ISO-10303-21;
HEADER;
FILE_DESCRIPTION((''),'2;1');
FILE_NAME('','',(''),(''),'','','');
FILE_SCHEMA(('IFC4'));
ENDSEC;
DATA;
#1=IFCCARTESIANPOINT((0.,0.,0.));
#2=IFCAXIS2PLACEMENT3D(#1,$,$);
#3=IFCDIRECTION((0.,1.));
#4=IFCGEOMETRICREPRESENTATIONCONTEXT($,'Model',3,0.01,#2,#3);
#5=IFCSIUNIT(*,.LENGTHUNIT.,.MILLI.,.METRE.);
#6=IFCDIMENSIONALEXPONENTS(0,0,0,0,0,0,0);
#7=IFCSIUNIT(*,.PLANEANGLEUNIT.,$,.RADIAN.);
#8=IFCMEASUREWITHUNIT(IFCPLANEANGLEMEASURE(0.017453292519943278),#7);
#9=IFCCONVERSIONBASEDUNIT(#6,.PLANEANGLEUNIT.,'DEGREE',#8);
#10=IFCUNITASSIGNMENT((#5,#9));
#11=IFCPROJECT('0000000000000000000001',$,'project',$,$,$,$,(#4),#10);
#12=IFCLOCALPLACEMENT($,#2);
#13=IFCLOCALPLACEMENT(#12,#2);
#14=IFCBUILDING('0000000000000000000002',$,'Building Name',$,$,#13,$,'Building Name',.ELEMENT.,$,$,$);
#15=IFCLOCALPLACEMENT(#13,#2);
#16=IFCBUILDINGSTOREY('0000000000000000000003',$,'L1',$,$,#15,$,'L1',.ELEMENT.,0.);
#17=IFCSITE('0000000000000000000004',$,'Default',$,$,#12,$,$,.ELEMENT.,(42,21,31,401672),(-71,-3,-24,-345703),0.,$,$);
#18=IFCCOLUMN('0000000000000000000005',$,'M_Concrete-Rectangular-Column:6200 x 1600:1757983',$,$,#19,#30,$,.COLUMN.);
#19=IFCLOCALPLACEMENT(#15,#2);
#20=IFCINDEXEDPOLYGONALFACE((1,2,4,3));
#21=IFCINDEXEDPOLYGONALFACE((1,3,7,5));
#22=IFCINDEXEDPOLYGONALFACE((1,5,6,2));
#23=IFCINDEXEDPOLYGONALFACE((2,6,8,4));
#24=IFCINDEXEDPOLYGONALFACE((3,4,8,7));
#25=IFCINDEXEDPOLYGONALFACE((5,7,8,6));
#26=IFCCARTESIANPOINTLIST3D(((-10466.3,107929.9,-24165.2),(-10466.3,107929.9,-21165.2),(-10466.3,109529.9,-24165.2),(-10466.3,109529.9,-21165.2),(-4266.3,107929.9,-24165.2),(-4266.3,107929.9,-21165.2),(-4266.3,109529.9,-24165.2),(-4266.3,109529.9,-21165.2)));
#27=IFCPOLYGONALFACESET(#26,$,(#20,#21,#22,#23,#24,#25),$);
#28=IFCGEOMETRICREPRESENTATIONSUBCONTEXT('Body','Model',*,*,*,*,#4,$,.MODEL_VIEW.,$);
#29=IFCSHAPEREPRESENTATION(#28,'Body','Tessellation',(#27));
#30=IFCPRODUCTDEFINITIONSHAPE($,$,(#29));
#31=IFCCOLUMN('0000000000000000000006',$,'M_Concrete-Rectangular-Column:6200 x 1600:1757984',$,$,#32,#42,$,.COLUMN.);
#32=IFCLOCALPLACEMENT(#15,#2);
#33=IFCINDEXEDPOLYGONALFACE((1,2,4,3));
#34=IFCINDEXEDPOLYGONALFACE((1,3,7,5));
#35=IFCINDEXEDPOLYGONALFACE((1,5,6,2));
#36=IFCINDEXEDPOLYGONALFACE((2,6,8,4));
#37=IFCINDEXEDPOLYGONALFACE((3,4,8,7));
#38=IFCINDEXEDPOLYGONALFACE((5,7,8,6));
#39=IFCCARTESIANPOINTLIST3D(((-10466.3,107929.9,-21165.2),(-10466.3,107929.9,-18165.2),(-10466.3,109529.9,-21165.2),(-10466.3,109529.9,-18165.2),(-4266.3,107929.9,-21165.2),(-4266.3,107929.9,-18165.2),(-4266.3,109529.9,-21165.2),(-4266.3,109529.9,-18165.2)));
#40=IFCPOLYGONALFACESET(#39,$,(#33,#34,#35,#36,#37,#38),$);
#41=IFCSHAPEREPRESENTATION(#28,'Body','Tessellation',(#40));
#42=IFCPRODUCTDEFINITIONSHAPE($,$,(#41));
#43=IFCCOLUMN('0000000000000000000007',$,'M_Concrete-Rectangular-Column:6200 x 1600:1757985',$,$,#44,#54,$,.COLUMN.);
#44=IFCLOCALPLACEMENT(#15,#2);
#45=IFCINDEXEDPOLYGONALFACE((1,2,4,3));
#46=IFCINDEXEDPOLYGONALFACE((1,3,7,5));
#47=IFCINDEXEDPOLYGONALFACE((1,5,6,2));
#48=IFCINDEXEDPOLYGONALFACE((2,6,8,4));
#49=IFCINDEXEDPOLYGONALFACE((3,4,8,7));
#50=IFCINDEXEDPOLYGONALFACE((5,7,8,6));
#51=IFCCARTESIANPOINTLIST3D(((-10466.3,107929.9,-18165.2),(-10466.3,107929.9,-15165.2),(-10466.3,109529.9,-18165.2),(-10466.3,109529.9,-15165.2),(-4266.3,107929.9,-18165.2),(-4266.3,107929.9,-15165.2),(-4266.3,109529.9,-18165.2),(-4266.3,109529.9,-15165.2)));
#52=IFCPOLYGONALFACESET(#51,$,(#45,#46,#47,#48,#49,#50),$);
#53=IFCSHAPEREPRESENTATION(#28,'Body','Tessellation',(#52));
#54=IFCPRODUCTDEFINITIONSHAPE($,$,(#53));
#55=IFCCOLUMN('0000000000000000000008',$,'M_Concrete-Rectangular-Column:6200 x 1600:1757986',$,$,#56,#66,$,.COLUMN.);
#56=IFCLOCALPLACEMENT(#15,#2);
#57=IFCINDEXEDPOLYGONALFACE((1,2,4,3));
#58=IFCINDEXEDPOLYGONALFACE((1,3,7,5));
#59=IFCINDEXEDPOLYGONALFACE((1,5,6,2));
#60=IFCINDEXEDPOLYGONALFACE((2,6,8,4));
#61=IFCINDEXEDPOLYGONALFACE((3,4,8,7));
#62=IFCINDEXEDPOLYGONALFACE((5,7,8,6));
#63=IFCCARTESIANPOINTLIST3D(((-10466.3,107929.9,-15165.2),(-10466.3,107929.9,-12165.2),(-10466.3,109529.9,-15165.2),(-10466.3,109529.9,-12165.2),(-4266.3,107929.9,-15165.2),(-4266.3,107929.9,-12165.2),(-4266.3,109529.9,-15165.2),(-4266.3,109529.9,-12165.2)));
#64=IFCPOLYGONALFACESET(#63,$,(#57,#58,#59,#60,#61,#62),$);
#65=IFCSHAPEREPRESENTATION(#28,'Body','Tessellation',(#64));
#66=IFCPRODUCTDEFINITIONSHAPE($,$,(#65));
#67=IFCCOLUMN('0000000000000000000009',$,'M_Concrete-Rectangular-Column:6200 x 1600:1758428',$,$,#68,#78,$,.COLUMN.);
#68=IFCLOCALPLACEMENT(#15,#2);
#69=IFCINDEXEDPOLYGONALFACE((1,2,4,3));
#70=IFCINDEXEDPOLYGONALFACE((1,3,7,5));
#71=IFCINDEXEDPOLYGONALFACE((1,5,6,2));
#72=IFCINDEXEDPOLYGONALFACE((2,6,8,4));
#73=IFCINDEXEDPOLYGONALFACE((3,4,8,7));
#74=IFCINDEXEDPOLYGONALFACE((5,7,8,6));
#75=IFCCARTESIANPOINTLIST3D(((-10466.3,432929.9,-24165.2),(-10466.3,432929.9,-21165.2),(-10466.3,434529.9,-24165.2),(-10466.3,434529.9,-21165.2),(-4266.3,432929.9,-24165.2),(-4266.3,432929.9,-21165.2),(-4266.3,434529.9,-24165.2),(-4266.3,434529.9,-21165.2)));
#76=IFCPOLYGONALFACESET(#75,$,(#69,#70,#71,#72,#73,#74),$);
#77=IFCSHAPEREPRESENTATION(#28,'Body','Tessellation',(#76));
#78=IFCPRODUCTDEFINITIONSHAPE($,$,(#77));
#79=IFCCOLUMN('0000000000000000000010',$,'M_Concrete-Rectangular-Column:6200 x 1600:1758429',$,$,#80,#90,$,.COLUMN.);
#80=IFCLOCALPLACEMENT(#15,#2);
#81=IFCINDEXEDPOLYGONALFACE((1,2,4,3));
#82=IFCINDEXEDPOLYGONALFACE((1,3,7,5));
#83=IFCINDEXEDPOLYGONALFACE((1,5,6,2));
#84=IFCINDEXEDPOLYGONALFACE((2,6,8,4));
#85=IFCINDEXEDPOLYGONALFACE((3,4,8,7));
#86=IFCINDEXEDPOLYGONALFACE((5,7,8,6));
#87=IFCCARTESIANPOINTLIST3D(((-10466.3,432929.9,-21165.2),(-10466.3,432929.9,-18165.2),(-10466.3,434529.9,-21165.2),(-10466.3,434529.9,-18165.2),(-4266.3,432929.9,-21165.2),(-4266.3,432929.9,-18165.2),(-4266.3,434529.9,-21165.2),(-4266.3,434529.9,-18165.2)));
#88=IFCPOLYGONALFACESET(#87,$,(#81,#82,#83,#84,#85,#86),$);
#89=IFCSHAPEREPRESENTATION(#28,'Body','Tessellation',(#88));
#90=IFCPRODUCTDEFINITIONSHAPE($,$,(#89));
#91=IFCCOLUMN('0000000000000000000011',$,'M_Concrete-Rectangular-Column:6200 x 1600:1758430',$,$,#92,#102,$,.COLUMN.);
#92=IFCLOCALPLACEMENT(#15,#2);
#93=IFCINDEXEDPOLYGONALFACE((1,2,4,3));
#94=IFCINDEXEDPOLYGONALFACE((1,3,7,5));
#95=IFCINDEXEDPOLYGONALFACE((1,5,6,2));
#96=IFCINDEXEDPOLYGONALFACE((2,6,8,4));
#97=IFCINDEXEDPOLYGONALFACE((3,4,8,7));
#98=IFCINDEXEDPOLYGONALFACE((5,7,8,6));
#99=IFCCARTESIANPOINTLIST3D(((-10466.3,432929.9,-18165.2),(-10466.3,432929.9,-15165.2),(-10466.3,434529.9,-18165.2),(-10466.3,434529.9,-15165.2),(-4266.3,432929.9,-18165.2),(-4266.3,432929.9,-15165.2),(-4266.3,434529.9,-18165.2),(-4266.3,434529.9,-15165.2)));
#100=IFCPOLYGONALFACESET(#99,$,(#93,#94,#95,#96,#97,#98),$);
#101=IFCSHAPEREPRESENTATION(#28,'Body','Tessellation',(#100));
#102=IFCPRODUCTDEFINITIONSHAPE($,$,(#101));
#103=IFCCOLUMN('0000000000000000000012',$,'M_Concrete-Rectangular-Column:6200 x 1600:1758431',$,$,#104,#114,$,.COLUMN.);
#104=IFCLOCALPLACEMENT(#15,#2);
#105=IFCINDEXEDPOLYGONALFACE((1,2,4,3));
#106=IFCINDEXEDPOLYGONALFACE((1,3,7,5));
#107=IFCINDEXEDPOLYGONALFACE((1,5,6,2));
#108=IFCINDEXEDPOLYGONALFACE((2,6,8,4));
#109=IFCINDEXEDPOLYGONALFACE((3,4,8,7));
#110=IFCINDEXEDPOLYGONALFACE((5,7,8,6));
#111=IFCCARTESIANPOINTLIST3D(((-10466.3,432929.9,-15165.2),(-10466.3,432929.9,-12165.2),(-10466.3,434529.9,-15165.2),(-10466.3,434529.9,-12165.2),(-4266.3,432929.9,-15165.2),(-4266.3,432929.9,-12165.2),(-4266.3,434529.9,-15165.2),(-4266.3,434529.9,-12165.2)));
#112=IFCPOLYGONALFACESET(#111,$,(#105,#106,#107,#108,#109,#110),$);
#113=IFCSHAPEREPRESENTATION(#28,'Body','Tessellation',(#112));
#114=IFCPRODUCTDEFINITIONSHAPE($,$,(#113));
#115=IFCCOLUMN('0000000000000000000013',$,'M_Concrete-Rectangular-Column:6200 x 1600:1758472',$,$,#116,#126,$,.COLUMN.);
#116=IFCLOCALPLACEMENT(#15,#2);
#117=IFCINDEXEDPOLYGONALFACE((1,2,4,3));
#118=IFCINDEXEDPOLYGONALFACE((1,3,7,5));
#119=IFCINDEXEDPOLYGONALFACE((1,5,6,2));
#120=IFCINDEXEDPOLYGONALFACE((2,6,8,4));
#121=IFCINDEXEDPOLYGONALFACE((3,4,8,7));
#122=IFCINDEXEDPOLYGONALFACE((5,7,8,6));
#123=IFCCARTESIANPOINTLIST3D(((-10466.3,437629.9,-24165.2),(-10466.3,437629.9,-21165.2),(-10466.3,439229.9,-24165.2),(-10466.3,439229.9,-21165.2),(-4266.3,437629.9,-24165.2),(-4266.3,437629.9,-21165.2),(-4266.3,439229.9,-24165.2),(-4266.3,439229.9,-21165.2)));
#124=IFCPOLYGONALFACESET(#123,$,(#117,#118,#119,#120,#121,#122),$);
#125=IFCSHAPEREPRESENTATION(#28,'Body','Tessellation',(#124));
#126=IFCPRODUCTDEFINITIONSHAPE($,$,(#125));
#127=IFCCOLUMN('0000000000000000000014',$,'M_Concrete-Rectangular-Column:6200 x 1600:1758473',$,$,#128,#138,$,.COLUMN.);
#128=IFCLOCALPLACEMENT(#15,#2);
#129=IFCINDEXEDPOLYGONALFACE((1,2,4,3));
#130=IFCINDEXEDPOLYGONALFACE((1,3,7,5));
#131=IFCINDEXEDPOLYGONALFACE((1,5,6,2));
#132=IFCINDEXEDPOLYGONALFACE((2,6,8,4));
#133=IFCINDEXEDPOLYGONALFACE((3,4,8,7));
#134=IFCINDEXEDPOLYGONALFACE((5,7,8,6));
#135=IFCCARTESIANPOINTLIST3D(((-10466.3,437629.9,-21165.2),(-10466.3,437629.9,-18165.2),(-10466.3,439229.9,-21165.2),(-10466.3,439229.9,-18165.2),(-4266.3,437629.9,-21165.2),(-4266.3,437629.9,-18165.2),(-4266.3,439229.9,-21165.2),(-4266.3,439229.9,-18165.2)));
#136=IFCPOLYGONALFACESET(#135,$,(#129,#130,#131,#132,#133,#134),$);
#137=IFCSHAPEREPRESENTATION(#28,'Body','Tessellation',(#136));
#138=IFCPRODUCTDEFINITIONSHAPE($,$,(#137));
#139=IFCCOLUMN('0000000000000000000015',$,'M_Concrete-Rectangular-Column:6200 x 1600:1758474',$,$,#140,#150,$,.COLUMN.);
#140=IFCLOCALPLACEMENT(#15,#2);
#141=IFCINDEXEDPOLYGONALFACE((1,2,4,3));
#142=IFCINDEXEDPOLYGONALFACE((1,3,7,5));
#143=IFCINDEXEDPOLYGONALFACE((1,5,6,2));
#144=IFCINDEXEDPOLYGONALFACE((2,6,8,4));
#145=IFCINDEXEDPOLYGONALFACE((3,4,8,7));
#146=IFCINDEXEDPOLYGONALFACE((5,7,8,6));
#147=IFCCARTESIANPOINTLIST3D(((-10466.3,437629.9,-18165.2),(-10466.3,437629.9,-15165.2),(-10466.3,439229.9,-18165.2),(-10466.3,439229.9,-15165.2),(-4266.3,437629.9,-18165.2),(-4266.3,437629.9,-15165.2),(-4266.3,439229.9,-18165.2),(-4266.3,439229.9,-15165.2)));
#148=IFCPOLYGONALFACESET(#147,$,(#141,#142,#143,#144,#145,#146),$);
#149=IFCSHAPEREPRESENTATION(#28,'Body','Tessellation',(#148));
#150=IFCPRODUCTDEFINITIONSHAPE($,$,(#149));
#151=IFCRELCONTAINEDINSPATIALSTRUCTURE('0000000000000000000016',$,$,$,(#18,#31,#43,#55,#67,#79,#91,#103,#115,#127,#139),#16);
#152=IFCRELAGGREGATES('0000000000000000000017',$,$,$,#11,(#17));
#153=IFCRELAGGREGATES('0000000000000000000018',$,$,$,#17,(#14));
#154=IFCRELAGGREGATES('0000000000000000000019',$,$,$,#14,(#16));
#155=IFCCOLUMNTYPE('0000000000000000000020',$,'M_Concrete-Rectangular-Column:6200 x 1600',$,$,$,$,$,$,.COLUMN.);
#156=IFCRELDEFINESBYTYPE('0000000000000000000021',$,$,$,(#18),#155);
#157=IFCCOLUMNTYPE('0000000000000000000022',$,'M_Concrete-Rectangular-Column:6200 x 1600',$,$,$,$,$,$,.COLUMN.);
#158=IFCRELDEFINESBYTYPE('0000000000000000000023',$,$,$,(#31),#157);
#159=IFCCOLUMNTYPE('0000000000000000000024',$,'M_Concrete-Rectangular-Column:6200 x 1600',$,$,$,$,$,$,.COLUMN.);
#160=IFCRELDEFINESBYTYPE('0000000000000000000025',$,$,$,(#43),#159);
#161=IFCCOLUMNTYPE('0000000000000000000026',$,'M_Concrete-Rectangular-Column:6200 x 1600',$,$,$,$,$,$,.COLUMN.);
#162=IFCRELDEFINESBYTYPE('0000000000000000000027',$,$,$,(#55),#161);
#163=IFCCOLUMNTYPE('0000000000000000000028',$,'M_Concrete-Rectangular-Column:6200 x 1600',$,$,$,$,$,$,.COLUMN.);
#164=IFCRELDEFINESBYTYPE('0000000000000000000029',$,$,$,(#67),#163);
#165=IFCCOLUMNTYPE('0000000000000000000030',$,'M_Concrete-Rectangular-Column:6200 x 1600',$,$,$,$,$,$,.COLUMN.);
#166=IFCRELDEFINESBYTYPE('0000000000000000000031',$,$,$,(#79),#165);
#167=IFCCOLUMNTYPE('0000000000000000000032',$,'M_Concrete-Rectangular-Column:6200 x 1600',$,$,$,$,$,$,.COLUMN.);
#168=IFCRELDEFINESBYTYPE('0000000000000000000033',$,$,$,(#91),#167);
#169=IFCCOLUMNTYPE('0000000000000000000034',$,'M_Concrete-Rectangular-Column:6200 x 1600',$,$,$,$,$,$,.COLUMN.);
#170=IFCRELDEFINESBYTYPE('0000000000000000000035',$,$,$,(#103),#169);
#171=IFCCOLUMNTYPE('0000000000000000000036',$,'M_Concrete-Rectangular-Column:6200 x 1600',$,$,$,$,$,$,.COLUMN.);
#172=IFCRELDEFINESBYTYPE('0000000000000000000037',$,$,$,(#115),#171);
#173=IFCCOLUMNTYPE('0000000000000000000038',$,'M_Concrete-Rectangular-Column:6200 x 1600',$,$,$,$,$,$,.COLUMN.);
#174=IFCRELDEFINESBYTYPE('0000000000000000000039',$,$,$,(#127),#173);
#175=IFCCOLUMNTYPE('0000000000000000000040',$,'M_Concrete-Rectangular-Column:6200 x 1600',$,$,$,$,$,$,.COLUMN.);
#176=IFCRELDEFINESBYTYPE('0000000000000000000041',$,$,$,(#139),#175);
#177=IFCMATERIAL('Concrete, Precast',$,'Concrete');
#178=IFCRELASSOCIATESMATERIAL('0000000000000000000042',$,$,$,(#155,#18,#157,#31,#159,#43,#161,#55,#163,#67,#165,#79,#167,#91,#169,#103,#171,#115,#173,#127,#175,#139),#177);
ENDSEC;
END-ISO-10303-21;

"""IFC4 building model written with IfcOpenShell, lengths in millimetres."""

from ifc_helpers import new_model, entity, si_unit, converted_unit, direction, frame, origin, place, context, subcontext, project, spatial, indexed_curve, outline, extrude, source, transform, mapped, material, type_object, type_shapes, element, save


model = new_model("IFC4")

# Units and contexts
model_context = context("Model", 3, precision=0.01, world=origin(), true_north=direction((0.0, 1.0)))
body_context = subcontext(model_context, "Body", "Model", "MODEL_VIEW")
ifc_project = project(units=[si_unit("LENGTHUNIT", "METRE", prefix="MILLI"), converted_unit("PLANEANGLEUNIT", "DEGREE", entity("IfcPlaneAngleMeasure", 0.017453292519943278), si_unit("PLANEANGLEUNIT", "RADIAN"), dimensions=[0, 0, 0, 0, 0, 0, 0])], contexts=[model_context])

# Site, building, storey
site_placement = place(None, origin())
site = spatial("IfcSite", under=ifc_project, at=site_placement, Name="Default", CompositionType="ELEMENT", RefLatitude=(42, 21, 31, 401672), RefLongitude=(-71, -3, -24, -345703), RefElevation=0.0)
building_placement = place(site_placement, origin())
building = spatial("IfcBuilding", under=site, at=building_placement, Name="Building Name", LongName="Building Name", CompositionType="ELEMENT")
storey_placement = place(building_placement, origin())
storey = spatial("IfcBuildingStorey", under=building, at=storey_placement, Name="L1", LongName="L1", CompositionType="ELEMENT", Elevation=0.0)

# Columns
ifc_material_1 = material(Name="Concrete, Precast", Category="Concrete")
column_type_1 = type_object("IfcColumnType", Name="M_Concrete-Rectangular-Column:6200 x 1600", PredefinedType="COLUMN", material=ifc_material_1)
shared_shape_1 = source(origin(), body_context, "Body", "SweptSolid", [
    extrude(outline(indexed_curve([(-800.0, -3100.0), (800.0, -3100.0), (800.0, 3100.0), (-800.0, 3100.0), (-800.0, -3100.0)], self_intersect=False)), frame((-7366.3, 108729.9, -24165.2), z_axis=(0.0, 0.0, 1.0), x_axis=(0.0, -1.0, 0.0)), (0.0, 0.0, 1.0), 3000.0),
])
type_shapes(column_type_1, [shared_shape_1])
column_1_placement = place(storey_placement, origin())
element("IfcColumn", 1, at=column_1_placement, inside=storey, type_object=column_type_1, material=ifc_material_1, Name="M_Concrete-Rectangular-Column:6200 x 1600:1757983", PredefinedType="COLUMN", context=body_context, shape_type="MappedRepresentation", body=[
    mapped(shared_shape_1, transform((0.0, 0.0, 0.0), scale=1.0)),
])
column_type_2 = type_object("IfcColumnType", Name="M_Concrete-Rectangular-Column:6200 x 1600", PredefinedType="COLUMN", material=ifc_material_1)
shared_shape_2 = source(origin(), body_context, "Body", "SweptSolid", [
    extrude(outline(indexed_curve([(-800.0, -3100.0), (800.0, -3100.0), (800.0, 3100.0), (-800.0, 3100.0), (-800.0, -3100.0)], self_intersect=False)), frame((-7366.3, 108729.9, -21165.2), z_axis=(0.0, 0.0, 1.0), x_axis=(0.0, -1.0, 0.0)), (0.0, 0.0, 1.0), 3000.0),
])
type_shapes(column_type_2, [shared_shape_2])
column_2_placement = place(storey_placement, origin())
element("IfcColumn", 2, at=column_2_placement, inside=storey, type_object=column_type_2, material=ifc_material_1, Name="M_Concrete-Rectangular-Column:6200 x 1600:1757984", PredefinedType="COLUMN", context=body_context, shape_type="MappedRepresentation", body=[
    mapped(shared_shape_2, transform((0.0, 0.0, 0.0), scale=1.0)),
])
column_type_3 = type_object("IfcColumnType", Name="M_Concrete-Rectangular-Column:6200 x 1600", PredefinedType="COLUMN", material=ifc_material_1)
shared_shape_3 = source(origin(), body_context, "Body", "SweptSolid", [
    extrude(outline(indexed_curve([(-800.0, -3100.0), (800.0, -3100.0), (800.0, 3100.0), (-800.0, 3100.0), (-800.0, -3100.0)], self_intersect=False)), frame((-7366.3, 108729.9, -18165.2), z_axis=(0.0, 0.0, 1.0), x_axis=(0.0, -1.0, 0.0)), (0.0, 0.0, 1.0), 3000.0),
])
type_shapes(column_type_3, [shared_shape_3])
column_3_placement = place(storey_placement, origin())
element("IfcColumn", 3, at=column_3_placement, inside=storey, type_object=column_type_3, material=ifc_material_1, Name="M_Concrete-Rectangular-Column:6200 x 1600:1757985", PredefinedType="COLUMN", context=body_context, shape_type="MappedRepresentation", body=[
    mapped(shared_shape_3, transform((0.0, 0.0, 0.0), scale=1.0)),
])
column_type_4 = type_object("IfcColumnType", Name="M_Concrete-Rectangular-Column:6200 x 1600", PredefinedType="COLUMN", material=ifc_material_1)
shared_shape_4 = source(origin(), body_context, "Body", "SweptSolid", [
    extrude(outline(indexed_curve([(-800.0, -3100.0), (800.0, -3100.0), (800.0, 3100.0), (-800.0, 3100.0), (-800.0, -3100.0)], self_intersect=False)), frame((-7366.3, 108729.9, -15165.2), z_axis=(0.0, 0.0, 1.0), x_axis=(0.0, -1.0, 0.0)), (0.0, 0.0, 1.0), 3000.0),
])
type_shapes(column_type_4, [shared_shape_4])
column_4_placement = place(storey_placement, origin())
element("IfcColumn", 4, at=column_4_placement, inside=storey, type_object=column_type_4, material=ifc_material_1, Name="M_Concrete-Rectangular-Column:6200 x 1600:1757986", PredefinedType="COLUMN", context=body_context, shape_type="MappedRepresentation", body=[
    mapped(shared_shape_4, transform((0.0, 0.0, 0.0), scale=1.0)),
])
column_type_5 = type_object("IfcColumnType", Name="M_Concrete-Rectangular-Column:6200 x 1600", PredefinedType="COLUMN", material=ifc_material_1)
shared_shape_5 = source(origin(), body_context, "Body", "SweptSolid", [
    extrude(outline(indexed_curve([(-800.0, -3100.0), (800.0, -3100.0), (800.0, 3100.0), (-800.0, 3100.0), (-800.0, -3100.0)], self_intersect=False)), frame((-7366.3, 433729.9, -24165.2), z_axis=(0.0, 0.0, 1.0), x_axis=(0.0, -1.0, 0.0)), (0.0, 0.0, 1.0), 3000.0),
])
type_shapes(column_type_5, [shared_shape_5])
column_5_placement = place(storey_placement, origin())
element("IfcColumn", 5, at=column_5_placement, inside=storey, type_object=column_type_5, material=ifc_material_1, Name="M_Concrete-Rectangular-Column:6200 x 1600:1758428", PredefinedType="COLUMN", context=body_context, shape_type="MappedRepresentation", body=[
    mapped(shared_shape_5, transform((0.0, 0.0, 0.0), scale=1.0)),
])
column_type_6 = type_object("IfcColumnType", Name="M_Concrete-Rectangular-Column:6200 x 1600", PredefinedType="COLUMN", material=ifc_material_1)
shared_shape_6 = source(origin(), body_context, "Body", "SweptSolid", [
    extrude(outline(indexed_curve([(-800.0, -3100.0), (800.0, -3100.0), (800.0, 3100.0), (-800.0, 3100.0), (-800.0, -3100.0)], self_intersect=False)), frame((-7366.3, 433729.9, -21165.2), z_axis=(0.0, 0.0, 1.0), x_axis=(0.0, -1.0, 0.0)), (0.0, 0.0, 1.0), 3000.0),
])
type_shapes(column_type_6, [shared_shape_6])
column_6_placement = place(storey_placement, origin())
element("IfcColumn", 6, at=column_6_placement, inside=storey, type_object=column_type_6, material=ifc_material_1, Name="M_Concrete-Rectangular-Column:6200 x 1600:1758429", PredefinedType="COLUMN", context=body_context, shape_type="MappedRepresentation", body=[
    mapped(shared_shape_6, transform((0.0, 0.0, 0.0), scale=1.0)),
])
column_type_7 = type_object("IfcColumnType", Name="M_Concrete-Rectangular-Column:6200 x 1600", PredefinedType="COLUMN", material=ifc_material_1)
shared_shape_7 = source(origin(), body_context, "Body", "SweptSolid", [
    extrude(outline(indexed_curve([(-800.0, -3100.0), (800.0, -3100.0), (800.0, 3100.0), (-800.0, 3100.0), (-800.0, -3100.0)], self_intersect=False)), frame((-7366.3, 433729.9, -18165.2), z_axis=(0.0, 0.0, 1.0), x_axis=(0.0, -1.0, 0.0)), (0.0, 0.0, 1.0), 3000.0),
])
type_shapes(column_type_7, [shared_shape_7])
column_7_placement = place(storey_placement, origin())
element("IfcColumn", 7, at=column_7_placement, inside=storey, type_object=column_type_7, material=ifc_material_1, Name="M_Concrete-Rectangular-Column:6200 x 1600:1758430", PredefinedType="COLUMN", context=body_context, shape_type="MappedRepresentation", body=[
    mapped(shared_shape_7, transform((0.0, 0.0, 0.0), scale=1.0)),
])
column_type_8 = type_object("IfcColumnType", Name="M_Concrete-Rectangular-Column:6200 x 1600", PredefinedType="COLUMN", material=ifc_material_1)
shared_shape_8 = source(origin(), body_context, "Body", "SweptSolid", [
    extrude(outline(indexed_curve([(-800.0, -3100.0), (800.0, -3100.0), (800.0, 3100.0), (-800.0, 3100.0), (-800.0, -3100.0)], self_intersect=False)), frame((-7366.3, 433729.9, -15165.2), z_axis=(0.0, 0.0, 1.0), x_axis=(0.0, -1.0, 0.0)), (0.0, 0.0, 1.0), 3000.0),
])
type_shapes(column_type_8, [shared_shape_8])
column_8_placement = place(storey_placement, origin())
element("IfcColumn", 8, at=column_8_placement, inside=storey, type_object=column_type_8, material=ifc_material_1, Name="M_Concrete-Rectangular-Column:6200 x 1600:1758431", PredefinedType="COLUMN", context=body_context, shape_type="MappedRepresentation", body=[
    mapped(shared_shape_8, transform((0.0, 0.0, 0.0), scale=1.0)),
])
column_type_9 = type_object("IfcColumnType", Name="M_Concrete-Rectangular-Column:6200 x 1600", PredefinedType="COLUMN", material=ifc_material_1)
shared_shape_9 = source(origin(), body_context, "Body", "SweptSolid", [
    extrude(outline(indexed_curve([(-800.0, -3100.0), (800.0, -3100.0), (800.0, 3100.0), (-800.0, 3100.0), (-800.0, -3100.0)], self_intersect=False)), frame((-7366.3, 438429.9, -24165.2), z_axis=(0.0, 0.0, 1.0), x_axis=(0.0, -1.0, 0.0)), (0.0, 0.0, 1.0), 3000.0),
])
type_shapes(column_type_9, [shared_shape_9])
column_9_placement = place(storey_placement, origin())
element("IfcColumn", 9, at=column_9_placement, inside=storey, type_object=column_type_9, material=ifc_material_1, Name="M_Concrete-Rectangular-Column:6200 x 1600:1758472", PredefinedType="COLUMN", context=body_context, shape_type="MappedRepresentation", body=[
    mapped(shared_shape_9, transform((0.0, 0.0, 0.0), scale=1.0)),
])
column_type_10 = type_object("IfcColumnType", Name="M_Concrete-Rectangular-Column:6200 x 1600", PredefinedType="COLUMN", material=ifc_material_1)
shared_shape_10 = source(origin(), body_context, "Body", "SweptSolid", [
    extrude(outline(indexed_curve([(-800.0, -3100.0), (800.0, -3100.0), (800.0, 3100.0), (-800.0, 3100.0), (-800.0, -3100.0)], self_intersect=False)), frame((-7366.3, 438429.9, -21165.2), z_axis=(0.0, 0.0, 1.0), x_axis=(0.0, -1.0, 0.0)), (0.0, 0.0, 1.0), 3000.0),
])
type_shapes(column_type_10, [shared_shape_10])
column_10_placement = place(storey_placement, origin())
element("IfcColumn", 10, at=column_10_placement, inside=storey, type_object=column_type_10, material=ifc_material_1, Name="M_Concrete-Rectangular-Column:6200 x 1600:1758473", PredefinedType="COLUMN", context=body_context, shape_type="MappedRepresentation", body=[
    mapped(shared_shape_10, transform((0.0, 0.0, 0.0), scale=1.0)),
])
column_type_11 = type_object("IfcColumnType", Name="M_Concrete-Rectangular-Column:6200 x 1600", PredefinedType="COLUMN", material=ifc_material_1)
shared_shape_11 = source(origin(), body_context, "Body", "SweptSolid", [
    extrude(outline(indexed_curve([(-800.0, -3100.0), (800.0, -3100.0), (800.0, 3100.0), (-800.0, 3100.0), (-800.0, -3100.0)], self_intersect=False)), frame((-7366.3, 438429.9, -18165.2), z_axis=(0.0, 0.0, 1.0), x_axis=(0.0, -1.0, 0.0)), (0.0, 0.0, 1.0), 3000.0),
])
type_shapes(column_type_11, [shared_shape_11])
column_11_placement = place(storey_placement, origin())
element("IfcColumn", 11, at=column_11_placement, inside=storey, type_object=column_type_11, material=ifc_material_1, Name="M_Concrete-Rectangular-Column:6200 x 1600:1758474", PredefinedType="COLUMN", context=body_context, shape_type="MappedRepresentation", body=[
    mapped(shared_shape_11, transform((0.0, 0.0, 0.0), scale=1.0)),
])

save(model, "model.ifc")
